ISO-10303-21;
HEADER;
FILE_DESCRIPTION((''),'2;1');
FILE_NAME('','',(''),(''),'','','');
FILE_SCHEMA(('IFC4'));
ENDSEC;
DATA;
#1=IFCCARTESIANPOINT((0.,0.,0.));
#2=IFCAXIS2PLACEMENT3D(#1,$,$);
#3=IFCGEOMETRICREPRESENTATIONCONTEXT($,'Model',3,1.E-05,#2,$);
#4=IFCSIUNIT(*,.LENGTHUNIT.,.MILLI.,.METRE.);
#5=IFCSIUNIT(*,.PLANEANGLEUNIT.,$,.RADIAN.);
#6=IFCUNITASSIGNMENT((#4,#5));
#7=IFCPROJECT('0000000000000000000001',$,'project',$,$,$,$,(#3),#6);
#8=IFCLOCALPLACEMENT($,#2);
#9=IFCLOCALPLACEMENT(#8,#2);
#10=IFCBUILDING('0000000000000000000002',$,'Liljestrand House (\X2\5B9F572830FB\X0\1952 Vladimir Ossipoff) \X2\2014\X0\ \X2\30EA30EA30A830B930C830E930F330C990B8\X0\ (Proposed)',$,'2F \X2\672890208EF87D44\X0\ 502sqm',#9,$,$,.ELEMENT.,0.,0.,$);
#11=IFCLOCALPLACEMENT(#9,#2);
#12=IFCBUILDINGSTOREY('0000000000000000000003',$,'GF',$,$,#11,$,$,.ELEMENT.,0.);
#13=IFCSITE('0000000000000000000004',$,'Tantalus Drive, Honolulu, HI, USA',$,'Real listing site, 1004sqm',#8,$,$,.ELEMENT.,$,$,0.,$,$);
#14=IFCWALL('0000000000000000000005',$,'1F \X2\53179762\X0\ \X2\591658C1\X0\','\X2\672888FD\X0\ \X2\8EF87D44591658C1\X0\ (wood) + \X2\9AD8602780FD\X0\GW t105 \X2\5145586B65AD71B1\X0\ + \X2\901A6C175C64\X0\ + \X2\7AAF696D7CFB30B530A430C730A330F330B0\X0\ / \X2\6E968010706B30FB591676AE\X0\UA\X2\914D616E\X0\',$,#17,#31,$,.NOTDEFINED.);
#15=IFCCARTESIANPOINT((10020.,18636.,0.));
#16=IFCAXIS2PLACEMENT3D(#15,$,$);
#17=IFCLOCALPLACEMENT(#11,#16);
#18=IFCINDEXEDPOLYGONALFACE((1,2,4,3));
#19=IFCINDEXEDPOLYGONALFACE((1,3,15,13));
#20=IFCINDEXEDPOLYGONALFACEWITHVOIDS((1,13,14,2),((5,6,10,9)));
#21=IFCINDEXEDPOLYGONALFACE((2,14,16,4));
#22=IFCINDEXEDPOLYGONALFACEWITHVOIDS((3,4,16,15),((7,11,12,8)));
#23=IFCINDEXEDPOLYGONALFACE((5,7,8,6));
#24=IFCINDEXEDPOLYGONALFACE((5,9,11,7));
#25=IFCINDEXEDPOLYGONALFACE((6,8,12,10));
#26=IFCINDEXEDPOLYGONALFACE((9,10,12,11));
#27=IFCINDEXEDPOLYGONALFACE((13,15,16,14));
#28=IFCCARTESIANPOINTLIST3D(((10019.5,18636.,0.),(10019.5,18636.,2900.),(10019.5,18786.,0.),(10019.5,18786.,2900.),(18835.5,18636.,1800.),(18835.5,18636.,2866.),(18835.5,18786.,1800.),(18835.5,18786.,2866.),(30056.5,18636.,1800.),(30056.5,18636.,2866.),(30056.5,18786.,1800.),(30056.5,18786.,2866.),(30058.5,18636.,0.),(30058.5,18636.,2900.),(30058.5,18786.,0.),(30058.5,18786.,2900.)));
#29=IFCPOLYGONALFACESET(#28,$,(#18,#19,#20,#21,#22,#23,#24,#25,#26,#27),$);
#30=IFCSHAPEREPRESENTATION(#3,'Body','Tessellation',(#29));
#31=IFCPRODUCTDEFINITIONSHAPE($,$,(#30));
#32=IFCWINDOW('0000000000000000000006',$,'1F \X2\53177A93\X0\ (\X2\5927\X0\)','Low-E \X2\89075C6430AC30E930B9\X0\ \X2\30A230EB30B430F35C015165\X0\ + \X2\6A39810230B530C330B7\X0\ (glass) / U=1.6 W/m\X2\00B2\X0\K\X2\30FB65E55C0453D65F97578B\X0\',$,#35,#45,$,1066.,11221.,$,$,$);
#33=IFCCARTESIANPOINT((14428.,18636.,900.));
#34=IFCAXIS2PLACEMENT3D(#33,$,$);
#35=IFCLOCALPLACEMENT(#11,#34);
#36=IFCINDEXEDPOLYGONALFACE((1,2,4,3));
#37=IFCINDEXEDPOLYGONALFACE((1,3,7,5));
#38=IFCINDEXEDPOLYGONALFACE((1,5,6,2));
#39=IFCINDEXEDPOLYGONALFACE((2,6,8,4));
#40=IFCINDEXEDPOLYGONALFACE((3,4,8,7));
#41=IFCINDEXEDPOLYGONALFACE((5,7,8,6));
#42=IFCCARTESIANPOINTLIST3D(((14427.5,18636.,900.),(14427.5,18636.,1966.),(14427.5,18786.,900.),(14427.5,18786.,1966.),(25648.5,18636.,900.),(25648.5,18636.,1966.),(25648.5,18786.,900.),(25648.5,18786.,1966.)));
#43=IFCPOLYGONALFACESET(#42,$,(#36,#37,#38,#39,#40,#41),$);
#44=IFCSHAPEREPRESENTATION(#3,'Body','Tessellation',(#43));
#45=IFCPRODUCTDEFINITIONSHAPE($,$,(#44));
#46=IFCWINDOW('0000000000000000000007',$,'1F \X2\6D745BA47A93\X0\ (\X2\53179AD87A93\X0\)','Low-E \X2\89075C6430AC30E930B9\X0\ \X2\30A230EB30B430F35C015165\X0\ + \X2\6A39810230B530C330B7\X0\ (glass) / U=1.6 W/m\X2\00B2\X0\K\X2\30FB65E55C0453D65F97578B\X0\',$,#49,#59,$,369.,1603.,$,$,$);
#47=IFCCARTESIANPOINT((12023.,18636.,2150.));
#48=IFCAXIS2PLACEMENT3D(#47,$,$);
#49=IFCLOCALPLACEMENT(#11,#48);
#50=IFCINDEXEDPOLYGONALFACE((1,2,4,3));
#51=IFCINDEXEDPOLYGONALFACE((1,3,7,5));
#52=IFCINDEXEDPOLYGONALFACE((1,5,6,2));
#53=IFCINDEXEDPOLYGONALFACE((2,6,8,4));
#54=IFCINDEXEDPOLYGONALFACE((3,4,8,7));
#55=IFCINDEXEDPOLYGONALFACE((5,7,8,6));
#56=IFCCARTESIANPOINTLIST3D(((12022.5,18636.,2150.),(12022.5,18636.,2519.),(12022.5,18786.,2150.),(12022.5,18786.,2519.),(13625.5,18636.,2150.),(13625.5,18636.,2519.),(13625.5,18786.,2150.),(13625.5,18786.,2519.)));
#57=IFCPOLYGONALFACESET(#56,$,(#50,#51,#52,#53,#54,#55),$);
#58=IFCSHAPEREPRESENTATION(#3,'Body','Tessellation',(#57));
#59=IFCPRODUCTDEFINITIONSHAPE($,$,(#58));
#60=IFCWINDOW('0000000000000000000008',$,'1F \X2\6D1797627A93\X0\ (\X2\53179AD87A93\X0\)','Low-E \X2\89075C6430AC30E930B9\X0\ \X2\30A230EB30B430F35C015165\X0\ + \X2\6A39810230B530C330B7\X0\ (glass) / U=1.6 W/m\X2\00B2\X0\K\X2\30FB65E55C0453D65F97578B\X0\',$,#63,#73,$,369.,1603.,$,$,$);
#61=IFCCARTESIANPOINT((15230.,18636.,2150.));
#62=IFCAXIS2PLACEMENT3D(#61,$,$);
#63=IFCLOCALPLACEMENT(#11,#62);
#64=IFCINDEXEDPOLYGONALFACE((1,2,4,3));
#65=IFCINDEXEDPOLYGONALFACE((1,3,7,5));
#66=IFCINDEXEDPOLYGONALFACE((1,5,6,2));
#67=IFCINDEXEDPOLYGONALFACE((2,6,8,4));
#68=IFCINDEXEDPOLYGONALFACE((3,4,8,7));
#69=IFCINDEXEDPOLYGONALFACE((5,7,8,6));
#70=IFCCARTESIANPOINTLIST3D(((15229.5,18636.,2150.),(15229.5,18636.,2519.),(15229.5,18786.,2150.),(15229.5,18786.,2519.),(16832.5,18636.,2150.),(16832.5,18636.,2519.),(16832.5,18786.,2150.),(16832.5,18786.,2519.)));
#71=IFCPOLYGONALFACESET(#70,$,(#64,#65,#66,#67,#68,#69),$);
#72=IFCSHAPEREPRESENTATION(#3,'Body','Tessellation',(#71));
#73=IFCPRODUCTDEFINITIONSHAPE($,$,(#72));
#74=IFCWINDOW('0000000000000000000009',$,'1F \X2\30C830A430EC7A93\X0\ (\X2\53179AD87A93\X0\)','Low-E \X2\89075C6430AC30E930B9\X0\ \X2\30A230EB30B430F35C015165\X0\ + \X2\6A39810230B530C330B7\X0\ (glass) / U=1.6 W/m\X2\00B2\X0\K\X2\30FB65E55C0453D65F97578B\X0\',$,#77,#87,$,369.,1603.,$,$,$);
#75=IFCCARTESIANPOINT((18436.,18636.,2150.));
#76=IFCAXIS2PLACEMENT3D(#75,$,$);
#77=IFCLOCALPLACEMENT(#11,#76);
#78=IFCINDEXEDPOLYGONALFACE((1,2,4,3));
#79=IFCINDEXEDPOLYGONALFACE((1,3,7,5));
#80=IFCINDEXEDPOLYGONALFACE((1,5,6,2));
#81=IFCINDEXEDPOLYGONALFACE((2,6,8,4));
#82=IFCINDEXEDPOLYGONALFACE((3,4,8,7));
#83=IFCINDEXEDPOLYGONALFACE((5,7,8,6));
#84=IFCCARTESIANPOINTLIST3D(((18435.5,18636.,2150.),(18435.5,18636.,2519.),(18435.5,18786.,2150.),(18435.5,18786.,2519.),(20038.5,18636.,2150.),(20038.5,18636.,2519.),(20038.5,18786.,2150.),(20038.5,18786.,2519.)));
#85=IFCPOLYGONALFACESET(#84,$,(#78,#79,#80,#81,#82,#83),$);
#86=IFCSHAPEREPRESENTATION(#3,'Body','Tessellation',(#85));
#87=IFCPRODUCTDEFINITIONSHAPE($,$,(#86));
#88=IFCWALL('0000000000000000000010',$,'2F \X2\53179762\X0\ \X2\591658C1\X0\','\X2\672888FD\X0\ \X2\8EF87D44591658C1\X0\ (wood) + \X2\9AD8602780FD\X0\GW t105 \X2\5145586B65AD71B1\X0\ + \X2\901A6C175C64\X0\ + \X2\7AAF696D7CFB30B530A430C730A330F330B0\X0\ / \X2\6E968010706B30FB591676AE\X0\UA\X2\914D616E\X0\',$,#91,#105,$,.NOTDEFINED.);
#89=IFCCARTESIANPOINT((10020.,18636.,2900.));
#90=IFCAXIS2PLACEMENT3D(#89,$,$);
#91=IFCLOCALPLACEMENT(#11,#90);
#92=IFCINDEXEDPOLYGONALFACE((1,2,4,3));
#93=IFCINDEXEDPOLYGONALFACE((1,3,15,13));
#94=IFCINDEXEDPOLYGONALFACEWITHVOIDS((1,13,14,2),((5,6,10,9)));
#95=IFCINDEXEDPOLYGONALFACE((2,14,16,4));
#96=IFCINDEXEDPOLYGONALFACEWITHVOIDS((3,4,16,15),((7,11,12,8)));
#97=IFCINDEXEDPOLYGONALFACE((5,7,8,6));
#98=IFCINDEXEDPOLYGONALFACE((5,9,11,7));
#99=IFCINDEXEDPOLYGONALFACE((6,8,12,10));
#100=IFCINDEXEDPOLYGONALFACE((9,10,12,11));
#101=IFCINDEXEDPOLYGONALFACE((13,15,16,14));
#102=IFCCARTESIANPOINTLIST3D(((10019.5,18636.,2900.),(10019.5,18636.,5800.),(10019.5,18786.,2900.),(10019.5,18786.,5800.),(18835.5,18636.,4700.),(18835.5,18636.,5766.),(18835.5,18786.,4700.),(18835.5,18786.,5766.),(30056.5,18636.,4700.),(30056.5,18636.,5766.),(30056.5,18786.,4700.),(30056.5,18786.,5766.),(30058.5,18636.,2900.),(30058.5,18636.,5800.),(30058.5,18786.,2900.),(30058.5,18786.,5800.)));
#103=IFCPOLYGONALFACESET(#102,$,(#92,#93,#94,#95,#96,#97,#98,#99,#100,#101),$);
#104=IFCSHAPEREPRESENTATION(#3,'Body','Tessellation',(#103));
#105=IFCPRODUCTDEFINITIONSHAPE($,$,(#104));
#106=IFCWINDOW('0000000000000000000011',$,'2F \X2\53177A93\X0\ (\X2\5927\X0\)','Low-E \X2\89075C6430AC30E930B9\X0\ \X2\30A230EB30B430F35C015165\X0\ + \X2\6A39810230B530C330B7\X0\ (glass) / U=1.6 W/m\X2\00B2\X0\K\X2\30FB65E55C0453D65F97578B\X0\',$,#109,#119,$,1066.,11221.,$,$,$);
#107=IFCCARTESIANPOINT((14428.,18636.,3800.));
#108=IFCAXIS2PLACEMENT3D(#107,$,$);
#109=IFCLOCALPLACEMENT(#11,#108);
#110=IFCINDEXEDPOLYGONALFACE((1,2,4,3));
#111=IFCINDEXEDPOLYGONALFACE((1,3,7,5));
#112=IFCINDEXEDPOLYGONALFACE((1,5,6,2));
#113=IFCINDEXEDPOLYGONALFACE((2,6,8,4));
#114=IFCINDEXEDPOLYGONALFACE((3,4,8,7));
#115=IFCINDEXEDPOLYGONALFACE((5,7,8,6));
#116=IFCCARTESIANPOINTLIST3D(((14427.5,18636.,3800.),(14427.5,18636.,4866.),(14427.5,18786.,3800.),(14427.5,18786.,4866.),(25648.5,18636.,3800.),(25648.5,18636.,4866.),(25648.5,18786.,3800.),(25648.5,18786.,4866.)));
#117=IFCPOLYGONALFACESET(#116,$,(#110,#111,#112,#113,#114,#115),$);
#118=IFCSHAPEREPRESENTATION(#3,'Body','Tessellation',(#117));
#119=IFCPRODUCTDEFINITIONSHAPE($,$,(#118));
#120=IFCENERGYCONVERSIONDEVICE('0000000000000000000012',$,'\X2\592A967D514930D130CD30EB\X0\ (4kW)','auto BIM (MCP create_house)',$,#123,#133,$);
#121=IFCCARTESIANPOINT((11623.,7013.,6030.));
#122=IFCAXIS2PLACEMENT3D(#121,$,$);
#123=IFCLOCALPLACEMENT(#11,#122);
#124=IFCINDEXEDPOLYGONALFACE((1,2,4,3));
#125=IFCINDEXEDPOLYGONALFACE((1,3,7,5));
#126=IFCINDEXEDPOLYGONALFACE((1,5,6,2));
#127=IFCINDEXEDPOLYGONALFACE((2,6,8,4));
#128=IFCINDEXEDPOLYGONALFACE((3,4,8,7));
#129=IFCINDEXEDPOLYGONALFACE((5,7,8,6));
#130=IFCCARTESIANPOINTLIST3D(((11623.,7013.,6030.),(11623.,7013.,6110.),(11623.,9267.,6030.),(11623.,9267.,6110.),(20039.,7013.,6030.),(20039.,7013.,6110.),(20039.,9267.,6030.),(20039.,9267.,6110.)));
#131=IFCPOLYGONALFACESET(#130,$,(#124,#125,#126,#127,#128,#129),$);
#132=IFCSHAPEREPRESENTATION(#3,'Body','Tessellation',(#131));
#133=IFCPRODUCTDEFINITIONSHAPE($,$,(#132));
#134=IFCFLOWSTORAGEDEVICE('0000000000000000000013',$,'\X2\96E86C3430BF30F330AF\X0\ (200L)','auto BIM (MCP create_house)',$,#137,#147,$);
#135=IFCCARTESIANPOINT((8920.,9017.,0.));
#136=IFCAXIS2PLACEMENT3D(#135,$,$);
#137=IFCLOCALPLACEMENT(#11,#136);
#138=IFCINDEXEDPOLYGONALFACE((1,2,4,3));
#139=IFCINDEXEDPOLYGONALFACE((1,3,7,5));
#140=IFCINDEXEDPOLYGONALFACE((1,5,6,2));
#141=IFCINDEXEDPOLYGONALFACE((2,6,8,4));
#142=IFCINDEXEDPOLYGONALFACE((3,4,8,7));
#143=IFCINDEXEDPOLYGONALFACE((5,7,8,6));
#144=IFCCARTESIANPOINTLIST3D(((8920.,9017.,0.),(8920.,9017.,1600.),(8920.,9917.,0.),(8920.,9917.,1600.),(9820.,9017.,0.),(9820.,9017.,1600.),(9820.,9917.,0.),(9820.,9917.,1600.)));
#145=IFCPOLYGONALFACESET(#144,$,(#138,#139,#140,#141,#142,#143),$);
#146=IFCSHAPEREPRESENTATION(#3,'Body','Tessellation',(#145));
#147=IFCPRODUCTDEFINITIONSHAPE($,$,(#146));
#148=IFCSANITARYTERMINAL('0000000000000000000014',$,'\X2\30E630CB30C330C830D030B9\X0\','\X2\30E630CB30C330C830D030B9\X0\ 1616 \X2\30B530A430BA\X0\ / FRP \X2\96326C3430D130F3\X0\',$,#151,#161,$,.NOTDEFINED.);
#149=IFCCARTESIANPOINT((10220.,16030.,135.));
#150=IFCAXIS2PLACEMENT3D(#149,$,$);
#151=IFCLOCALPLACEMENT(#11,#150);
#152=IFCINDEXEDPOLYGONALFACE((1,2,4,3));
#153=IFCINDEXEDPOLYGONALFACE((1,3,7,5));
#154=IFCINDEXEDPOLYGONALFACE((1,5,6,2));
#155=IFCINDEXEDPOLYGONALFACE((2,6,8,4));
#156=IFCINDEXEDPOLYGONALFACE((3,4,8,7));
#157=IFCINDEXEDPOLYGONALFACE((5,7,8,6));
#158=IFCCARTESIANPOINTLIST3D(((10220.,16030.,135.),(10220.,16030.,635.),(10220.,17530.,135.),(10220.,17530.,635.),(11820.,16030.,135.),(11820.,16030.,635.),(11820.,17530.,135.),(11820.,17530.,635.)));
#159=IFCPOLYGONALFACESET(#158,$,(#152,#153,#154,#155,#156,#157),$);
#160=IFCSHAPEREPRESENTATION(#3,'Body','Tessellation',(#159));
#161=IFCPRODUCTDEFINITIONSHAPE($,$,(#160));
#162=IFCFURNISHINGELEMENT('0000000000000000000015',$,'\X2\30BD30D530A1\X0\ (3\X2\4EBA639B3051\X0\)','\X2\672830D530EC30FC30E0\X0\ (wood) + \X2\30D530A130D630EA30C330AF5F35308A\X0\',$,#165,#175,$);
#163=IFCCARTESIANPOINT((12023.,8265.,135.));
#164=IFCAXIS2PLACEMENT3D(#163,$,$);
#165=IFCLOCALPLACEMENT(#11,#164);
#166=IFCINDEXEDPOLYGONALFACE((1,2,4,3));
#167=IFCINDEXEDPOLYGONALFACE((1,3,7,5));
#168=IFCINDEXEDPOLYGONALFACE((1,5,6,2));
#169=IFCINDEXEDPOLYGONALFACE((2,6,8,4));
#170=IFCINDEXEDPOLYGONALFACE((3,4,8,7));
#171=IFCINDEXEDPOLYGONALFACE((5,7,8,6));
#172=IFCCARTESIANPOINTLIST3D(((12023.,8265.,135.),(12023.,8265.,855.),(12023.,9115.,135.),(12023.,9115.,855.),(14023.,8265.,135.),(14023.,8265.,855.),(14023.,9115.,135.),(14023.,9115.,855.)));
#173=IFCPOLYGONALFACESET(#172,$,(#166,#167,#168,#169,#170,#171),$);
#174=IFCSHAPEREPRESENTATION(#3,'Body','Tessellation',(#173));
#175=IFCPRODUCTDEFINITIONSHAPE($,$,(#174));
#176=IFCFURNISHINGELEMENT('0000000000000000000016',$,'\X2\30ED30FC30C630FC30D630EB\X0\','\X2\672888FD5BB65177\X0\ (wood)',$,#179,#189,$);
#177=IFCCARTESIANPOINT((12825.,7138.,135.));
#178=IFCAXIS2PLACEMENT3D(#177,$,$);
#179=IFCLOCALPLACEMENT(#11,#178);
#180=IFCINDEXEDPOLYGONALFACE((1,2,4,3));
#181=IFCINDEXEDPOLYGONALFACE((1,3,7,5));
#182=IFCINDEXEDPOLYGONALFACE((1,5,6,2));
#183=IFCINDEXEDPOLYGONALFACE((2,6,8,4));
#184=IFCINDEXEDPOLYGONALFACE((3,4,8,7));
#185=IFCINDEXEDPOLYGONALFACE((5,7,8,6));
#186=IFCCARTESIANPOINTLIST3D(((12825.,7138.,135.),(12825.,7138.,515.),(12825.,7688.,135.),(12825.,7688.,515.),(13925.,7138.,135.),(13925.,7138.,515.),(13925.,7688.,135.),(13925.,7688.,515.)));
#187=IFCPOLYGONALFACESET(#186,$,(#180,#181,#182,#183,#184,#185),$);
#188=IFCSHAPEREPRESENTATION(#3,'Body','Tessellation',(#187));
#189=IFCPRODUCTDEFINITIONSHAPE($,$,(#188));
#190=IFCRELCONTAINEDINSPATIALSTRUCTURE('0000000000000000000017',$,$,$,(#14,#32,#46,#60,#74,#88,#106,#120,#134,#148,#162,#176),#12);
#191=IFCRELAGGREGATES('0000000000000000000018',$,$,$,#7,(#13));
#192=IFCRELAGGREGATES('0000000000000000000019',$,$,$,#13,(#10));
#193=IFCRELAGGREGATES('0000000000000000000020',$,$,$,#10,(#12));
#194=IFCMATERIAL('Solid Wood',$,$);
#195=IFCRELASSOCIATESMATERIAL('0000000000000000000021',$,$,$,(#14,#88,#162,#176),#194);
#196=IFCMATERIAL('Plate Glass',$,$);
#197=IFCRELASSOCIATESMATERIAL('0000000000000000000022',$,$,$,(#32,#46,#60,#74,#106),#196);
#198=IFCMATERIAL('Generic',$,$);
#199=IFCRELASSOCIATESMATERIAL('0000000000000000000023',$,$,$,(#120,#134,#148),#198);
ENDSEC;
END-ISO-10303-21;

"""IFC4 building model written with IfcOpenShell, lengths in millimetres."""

from ifc_helpers import new_model, si_unit, frame, frame_2d, origin, place, context, project, spatial, rectangle, extrude, material, element, fill, save


model = new_model("IFC4")

# Units and contexts
model_context = context("Model", 3, precision=1e-05, world=origin())
ifc_project = project(units=[si_unit("LENGTHUNIT", "METRE", prefix="MILLI"), si_unit("PLANEANGLEUNIT", "RADIAN")], contexts=[model_context])

# Site, building, storey
site_placement = place(None, origin())
site = spatial("IfcSite", under=ifc_project, at=site_placement, Name="Tantalus Drive, Honolulu, HI, USA", ObjectType="Real listing site, 1004sqm", CompositionType="ELEMENT", RefElevation=0.0)
building_placement = place(site_placement, origin())
building = spatial("IfcBuilding", under=site, at=building_placement, Name="Liljestrand House (実在・1952 Vladimir Ossipoff) — リリエストランド邸 (Proposed)", ObjectType="2F 木造軸組 502sqm", CompositionType="ELEMENT", ElevationOfRefHeight=0.0, ElevationOfTerrain=0.0)
storey_placement = place(building_placement, origin())
storey = spatial("IfcBuildingStorey", under=building, at=storey_placement, Name="GF", CompositionType="ELEMENT", Elevation=0.0)

# Wall, openings, windows
ifc_material_1 = material(Name="Solid Wood")
wall_1_placement = place(storey_placement, frame((10020.0, 18636.0, 0.0)))
wall_1 = element("IfcWall", 1, at=wall_1_placement, inside=storey, material=ifc_material_1, Name="1F 北面 外壁", Description="木製 軸組外壁 (wood) + 高性能GW t105 充填断熱 + 通気層 + 窯業系サイディング / 準耐火・外皮UA配慮", PredefinedType="NOTDEFINED", context=model_context, shape_type="SweptSolid", body=[
    extrude(rectangle(XDim=20039.0, YDim=150.0, at=frame_2d((10019.0, 75.0))), frame((10020.0, 18636.0, 0.0)), (0.0, 0.0, 1.0), 2900.0),
])
opening_1_placement = place(storey_placement, frame((14428.0, 18636.0, 900.0)))
opening_1 = element("IfcOpeningElement", 2, at=opening_1_placement, cuts=wall_1, PredefinedType="NOTDEFINED", context=model_context, shape_type="SweptSolid", body=[
    extrude(rectangle(XDim=11221.0, YDim=150.0, at=frame_2d((5610.0, 75.0))), frame((14428.0, 18636.0, 900.0)), (0.0, 0.0, 1.0), 1066.0),
])
opening_2_placement = place(storey_placement, frame((12023.0, 18636.0, 2150.0)))
opening_2 = element("IfcOpeningElement", 3, at=opening_2_placement, cuts=wall_1, PredefinedType="NOTDEFINED", context=model_context, shape_type="SweptSolid", body=[
    extrude(rectangle(XDim=1603.0, YDim=150.0, at=frame_2d((801.0, 75.0))), frame((12023.0, 18636.0, 2150.0)), (0.0, 0.0, 1.0), 369.0),
])
opening_3_placement = place(storey_placement, frame((15230.0, 18636.0, 2150.0)))
opening_3 = element("IfcOpeningElement", 4, at=opening_3_placement, cuts=wall_1, PredefinedType="NOTDEFINED", context=model_context, shape_type="SweptSolid", body=[
    extrude(rectangle(XDim=1603.0, YDim=150.0, at=frame_2d((801.0, 75.0))), frame((15230.0, 18636.0, 2150.0)), (0.0, 0.0, 1.0), 369.0),
])
opening_4_placement = place(storey_placement, frame((18436.0, 18636.0, 2150.0)))
opening_4 = element("IfcOpeningElement", 5, at=opening_4_placement, cuts=wall_1, PredefinedType="NOTDEFINED", context=model_context, shape_type="SweptSolid", body=[
    extrude(rectangle(XDim=1603.0, YDim=150.0, at=frame_2d((801.0, 75.0))), frame((18436.0, 18636.0, 2150.0)), (0.0, 0.0, 1.0), 369.0),
])
ifc_material_2 = material(Name="Plate Glass")
window_1_placement = place(storey_placement, frame((14428.0, 18636.0, 900.0)))
window_1 = element("IfcWindow", 6, at=window_1_placement, inside=storey, material=ifc_material_2, Name="1F 北窓 (大)", Description="Low-E 複層ガラス アルゴン封入 + 樹脂サッシ (glass) / U=1.6 W/m²K・日射取得型", OverallHeight=1066.0, OverallWidth=11221.0, context=model_context, shape_type="SweptSolid", body=[
    extrude(rectangle(XDim=11221.0, YDim=150.0, at=frame_2d((5610.0, 75.0))), frame((14428.0, 18636.0, 900.0)), (0.0, 0.0, 1.0), 1066.0),
])
fill(opening_1, window_1)
window_2_placement = place(storey_placement, frame((12023.0, 18636.0, 2150.0)))
window_2 = element("IfcWindow", 7, at=window_2_placement, inside=storey, material=ifc_material_2, Name="1F 浴室窓 (北高窓)", Description="Low-E 複層ガラス アルゴン封入 + 樹脂サッシ (glass) / U=1.6 W/m²K・日射取得型", OverallHeight=369.0, OverallWidth=1603.0, context=model_context, shape_type="SweptSolid", body=[
    extrude(rectangle(XDim=1603.0, YDim=150.0, at=frame_2d((801.0, 75.0))), frame((12023.0, 18636.0, 2150.0)), (0.0, 0.0, 1.0), 369.0),
])
fill(opening_2, window_2)
window_3_placement = place(storey_placement, frame((15230.0, 18636.0, 2150.0)))
window_3 = element("IfcWindow", 8, at=window_3_placement, inside=storey, material=ifc_material_2, Name="1F 洗面窓 (北高窓)", Description="Low-E 複層ガラス アルゴン封入 + 樹脂サッシ (glass) / U=1.6 W/m²K・日射取得型", OverallHeight=369.0, OverallWidth=1603.0, context=model_context, shape_type="SweptSolid", body=[
    extrude(rectangle(XDim=1603.0, YDim=150.0, at=frame_2d((801.0, 75.0))), frame((15230.0, 18636.0, 2150.0)), (0.0, 0.0, 1.0), 369.0),
])
fill(opening_3, window_3)
window_4_placement = place(storey_placement, frame((18436.0, 18636.0, 2150.0)))
window_4 = element("IfcWindow", 9, at=window_4_placement, inside=storey, material=ifc_material_2, Name="1F トイレ窓 (北高窓)", Description="Low-E 複層ガラス アルゴン封入 + 樹脂サッシ (glass) / U=1.6 W/m²K・日射取得型", OverallHeight=369.0, OverallWidth=1603.0, context=model_context, shape_type="SweptSolid", body=[
    extrude(rectangle(XDim=1603.0, YDim=150.0, at=frame_2d((801.0, 75.0))), frame((18436.0, 18636.0, 2150.0)), (0.0, 0.0, 1.0), 369.0),
])
fill(opening_4, window_4)

# Wall, opening, window
wall_2_placement = place(storey_placement, frame((10020.0, 18636.0, 2900.0)))
wall_2 = element("IfcWall", 10, at=wall_2_placement, inside=storey, material=ifc_material_1, Name="2F 北面 外壁", Description="木製 軸組外壁 (wood) + 高性能GW t105 充填断熱 + 通気層 + 窯業系サイディング / 準耐火・外皮UA配慮", PredefinedType="NOTDEFINED", context=model_context, shape_type="SweptSolid", body=[
    extrude(rectangle(XDim=20039.0, YDim=150.0, at=frame_2d((10019.0, 75.0))), frame((10020.0, 18636.0, 2900.0)), (0.0, 0.0, 1.0), 2900.0),
])
opening_5_placement = place(storey_placement, frame((14428.0, 18636.0, 3800.0)))
opening_5 = element("IfcOpeningElement", 11, at=opening_5_placement, cuts=wall_2, PredefinedType="NOTDEFINED", context=model_context, shape_type="SweptSolid", body=[
    extrude(rectangle(XDim=11221.0, YDim=150.0, at=frame_2d((5610.0, 75.0))), frame((14428.0, 18636.0, 3800.0)), (0.0, 0.0, 1.0), 1066.0),
])
window_5_placement = place(storey_placement, frame((14428.0, 18636.0, 3800.0)))
window_5 = element("IfcWindow", 12, at=window_5_placement, inside=storey, material=ifc_material_2, Name="2F 北窓 (大)", Description="Low-E 複層ガラス アルゴン封入 + 樹脂サッシ (glass) / U=1.6 W/m²K・日射取得型", OverallHeight=1066.0, OverallWidth=11221.0, context=model_context, shape_type="SweptSolid", body=[
    extrude(rectangle(XDim=11221.0, YDim=150.0, at=frame_2d((5610.0, 75.0))), frame((14428.0, 18636.0, 3800.0)), (0.0, 0.0, 1.0), 1066.0),
])
fill(opening_5, window_5)

# Energy conversion device
ifc_material_3 = material(Name="Generic")
energy_conversion_device_placement = place(storey_placement, frame((11623.0, 7013.0, 6030.0)))
element("IfcEnergyConversionDevice", 13, at=energy_conversion_device_placement, inside=storey, material=ifc_material_3, Name="太陽光パネル (4kW)", Description="auto BIM (MCP create_house)", context=model_context, shape_type="SweptSolid", body=[
    extrude(rectangle(XDim=8416.0, YDim=2254.0, at=frame_2d((4208.0, 1127.0))), frame((11623.0, 7013.0, 6030.0)), (0.0, 0.0, 1.0), 80.0),
])

# Flow storage device
flow_storage_device_placement = place(storey_placement, frame((8920.0, 9017.0, 0.0)))
element("IfcFlowStorageDevice", 14, at=flow_storage_device_placement, inside=storey, material=ifc_material_3, Name="雨水タンク (200L)", Description="auto BIM (MCP create_house)", context=model_context, shape_type="SweptSolid", body=[
    extrude(rectangle(XDim=900.0, YDim=900.0, at=frame_2d((450.0, 450.0))), frame((8920.0, 9017.0, 0.0)), (0.0, 0.0, 1.0), 1600.0),
])

# Sanitary terminal
sanitary_terminal_placement = place(storey_placement, frame((10220.0, 16030.0, 135.0)))
element("IfcSanitaryTerminal", 15, at=sanitary_terminal_placement, inside=storey, material=ifc_material_3, Name="ユニットバス", Description="ユニットバス 1616 サイズ / FRP 防水パン", PredefinedType="NOTDEFINED", context=model_context, shape_type="SweptSolid", body=[
    extrude(rectangle(XDim=1600.0, YDim=1500.0, at=frame_2d((800.0, 750.0))), frame((10220.0, 16030.0, 135.0)), (0.0, 0.0, 1.0), 500.0),
])

# Furnishing elements
furnishing_1_placement = place(storey_placement, frame((12023.0, 8265.0, 135.0)))
element("IfcFurnishingElement", 16, at=furnishing_1_placement, inside=storey, material=ifc_material_1, Name="ソファ (3人掛け)", Description="木フレーム (wood) + ファブリック張り", context=model_context, shape_type="SweptSolid", body=[
    extrude(rectangle(XDim=2000.0, YDim=850.0, at=frame_2d((1000.0, 425.0))), frame((12023.0, 8265.0, 135.0)), (0.0, 0.0, 1.0), 720.0),
])
furnishing_2_placement = place(storey_placement, frame((12825.0, 7138.0, 135.0)))
element("IfcFurnishingElement", 17, at=furnishing_2_placement, inside=storey, material=ifc_material_1, Name="ローテーブル", Description="木製家具 (wood)", context=model_context, shape_type="SweptSolid", body=[
    extrude(rectangle(XDim=1100.0, YDim=550.0, at=frame_2d((550.0, 275.0))), frame((12825.0, 7138.0, 135.0)), (0.0, 0.0, 1.0), 380.0),
])

save(model, "model.ifc")
